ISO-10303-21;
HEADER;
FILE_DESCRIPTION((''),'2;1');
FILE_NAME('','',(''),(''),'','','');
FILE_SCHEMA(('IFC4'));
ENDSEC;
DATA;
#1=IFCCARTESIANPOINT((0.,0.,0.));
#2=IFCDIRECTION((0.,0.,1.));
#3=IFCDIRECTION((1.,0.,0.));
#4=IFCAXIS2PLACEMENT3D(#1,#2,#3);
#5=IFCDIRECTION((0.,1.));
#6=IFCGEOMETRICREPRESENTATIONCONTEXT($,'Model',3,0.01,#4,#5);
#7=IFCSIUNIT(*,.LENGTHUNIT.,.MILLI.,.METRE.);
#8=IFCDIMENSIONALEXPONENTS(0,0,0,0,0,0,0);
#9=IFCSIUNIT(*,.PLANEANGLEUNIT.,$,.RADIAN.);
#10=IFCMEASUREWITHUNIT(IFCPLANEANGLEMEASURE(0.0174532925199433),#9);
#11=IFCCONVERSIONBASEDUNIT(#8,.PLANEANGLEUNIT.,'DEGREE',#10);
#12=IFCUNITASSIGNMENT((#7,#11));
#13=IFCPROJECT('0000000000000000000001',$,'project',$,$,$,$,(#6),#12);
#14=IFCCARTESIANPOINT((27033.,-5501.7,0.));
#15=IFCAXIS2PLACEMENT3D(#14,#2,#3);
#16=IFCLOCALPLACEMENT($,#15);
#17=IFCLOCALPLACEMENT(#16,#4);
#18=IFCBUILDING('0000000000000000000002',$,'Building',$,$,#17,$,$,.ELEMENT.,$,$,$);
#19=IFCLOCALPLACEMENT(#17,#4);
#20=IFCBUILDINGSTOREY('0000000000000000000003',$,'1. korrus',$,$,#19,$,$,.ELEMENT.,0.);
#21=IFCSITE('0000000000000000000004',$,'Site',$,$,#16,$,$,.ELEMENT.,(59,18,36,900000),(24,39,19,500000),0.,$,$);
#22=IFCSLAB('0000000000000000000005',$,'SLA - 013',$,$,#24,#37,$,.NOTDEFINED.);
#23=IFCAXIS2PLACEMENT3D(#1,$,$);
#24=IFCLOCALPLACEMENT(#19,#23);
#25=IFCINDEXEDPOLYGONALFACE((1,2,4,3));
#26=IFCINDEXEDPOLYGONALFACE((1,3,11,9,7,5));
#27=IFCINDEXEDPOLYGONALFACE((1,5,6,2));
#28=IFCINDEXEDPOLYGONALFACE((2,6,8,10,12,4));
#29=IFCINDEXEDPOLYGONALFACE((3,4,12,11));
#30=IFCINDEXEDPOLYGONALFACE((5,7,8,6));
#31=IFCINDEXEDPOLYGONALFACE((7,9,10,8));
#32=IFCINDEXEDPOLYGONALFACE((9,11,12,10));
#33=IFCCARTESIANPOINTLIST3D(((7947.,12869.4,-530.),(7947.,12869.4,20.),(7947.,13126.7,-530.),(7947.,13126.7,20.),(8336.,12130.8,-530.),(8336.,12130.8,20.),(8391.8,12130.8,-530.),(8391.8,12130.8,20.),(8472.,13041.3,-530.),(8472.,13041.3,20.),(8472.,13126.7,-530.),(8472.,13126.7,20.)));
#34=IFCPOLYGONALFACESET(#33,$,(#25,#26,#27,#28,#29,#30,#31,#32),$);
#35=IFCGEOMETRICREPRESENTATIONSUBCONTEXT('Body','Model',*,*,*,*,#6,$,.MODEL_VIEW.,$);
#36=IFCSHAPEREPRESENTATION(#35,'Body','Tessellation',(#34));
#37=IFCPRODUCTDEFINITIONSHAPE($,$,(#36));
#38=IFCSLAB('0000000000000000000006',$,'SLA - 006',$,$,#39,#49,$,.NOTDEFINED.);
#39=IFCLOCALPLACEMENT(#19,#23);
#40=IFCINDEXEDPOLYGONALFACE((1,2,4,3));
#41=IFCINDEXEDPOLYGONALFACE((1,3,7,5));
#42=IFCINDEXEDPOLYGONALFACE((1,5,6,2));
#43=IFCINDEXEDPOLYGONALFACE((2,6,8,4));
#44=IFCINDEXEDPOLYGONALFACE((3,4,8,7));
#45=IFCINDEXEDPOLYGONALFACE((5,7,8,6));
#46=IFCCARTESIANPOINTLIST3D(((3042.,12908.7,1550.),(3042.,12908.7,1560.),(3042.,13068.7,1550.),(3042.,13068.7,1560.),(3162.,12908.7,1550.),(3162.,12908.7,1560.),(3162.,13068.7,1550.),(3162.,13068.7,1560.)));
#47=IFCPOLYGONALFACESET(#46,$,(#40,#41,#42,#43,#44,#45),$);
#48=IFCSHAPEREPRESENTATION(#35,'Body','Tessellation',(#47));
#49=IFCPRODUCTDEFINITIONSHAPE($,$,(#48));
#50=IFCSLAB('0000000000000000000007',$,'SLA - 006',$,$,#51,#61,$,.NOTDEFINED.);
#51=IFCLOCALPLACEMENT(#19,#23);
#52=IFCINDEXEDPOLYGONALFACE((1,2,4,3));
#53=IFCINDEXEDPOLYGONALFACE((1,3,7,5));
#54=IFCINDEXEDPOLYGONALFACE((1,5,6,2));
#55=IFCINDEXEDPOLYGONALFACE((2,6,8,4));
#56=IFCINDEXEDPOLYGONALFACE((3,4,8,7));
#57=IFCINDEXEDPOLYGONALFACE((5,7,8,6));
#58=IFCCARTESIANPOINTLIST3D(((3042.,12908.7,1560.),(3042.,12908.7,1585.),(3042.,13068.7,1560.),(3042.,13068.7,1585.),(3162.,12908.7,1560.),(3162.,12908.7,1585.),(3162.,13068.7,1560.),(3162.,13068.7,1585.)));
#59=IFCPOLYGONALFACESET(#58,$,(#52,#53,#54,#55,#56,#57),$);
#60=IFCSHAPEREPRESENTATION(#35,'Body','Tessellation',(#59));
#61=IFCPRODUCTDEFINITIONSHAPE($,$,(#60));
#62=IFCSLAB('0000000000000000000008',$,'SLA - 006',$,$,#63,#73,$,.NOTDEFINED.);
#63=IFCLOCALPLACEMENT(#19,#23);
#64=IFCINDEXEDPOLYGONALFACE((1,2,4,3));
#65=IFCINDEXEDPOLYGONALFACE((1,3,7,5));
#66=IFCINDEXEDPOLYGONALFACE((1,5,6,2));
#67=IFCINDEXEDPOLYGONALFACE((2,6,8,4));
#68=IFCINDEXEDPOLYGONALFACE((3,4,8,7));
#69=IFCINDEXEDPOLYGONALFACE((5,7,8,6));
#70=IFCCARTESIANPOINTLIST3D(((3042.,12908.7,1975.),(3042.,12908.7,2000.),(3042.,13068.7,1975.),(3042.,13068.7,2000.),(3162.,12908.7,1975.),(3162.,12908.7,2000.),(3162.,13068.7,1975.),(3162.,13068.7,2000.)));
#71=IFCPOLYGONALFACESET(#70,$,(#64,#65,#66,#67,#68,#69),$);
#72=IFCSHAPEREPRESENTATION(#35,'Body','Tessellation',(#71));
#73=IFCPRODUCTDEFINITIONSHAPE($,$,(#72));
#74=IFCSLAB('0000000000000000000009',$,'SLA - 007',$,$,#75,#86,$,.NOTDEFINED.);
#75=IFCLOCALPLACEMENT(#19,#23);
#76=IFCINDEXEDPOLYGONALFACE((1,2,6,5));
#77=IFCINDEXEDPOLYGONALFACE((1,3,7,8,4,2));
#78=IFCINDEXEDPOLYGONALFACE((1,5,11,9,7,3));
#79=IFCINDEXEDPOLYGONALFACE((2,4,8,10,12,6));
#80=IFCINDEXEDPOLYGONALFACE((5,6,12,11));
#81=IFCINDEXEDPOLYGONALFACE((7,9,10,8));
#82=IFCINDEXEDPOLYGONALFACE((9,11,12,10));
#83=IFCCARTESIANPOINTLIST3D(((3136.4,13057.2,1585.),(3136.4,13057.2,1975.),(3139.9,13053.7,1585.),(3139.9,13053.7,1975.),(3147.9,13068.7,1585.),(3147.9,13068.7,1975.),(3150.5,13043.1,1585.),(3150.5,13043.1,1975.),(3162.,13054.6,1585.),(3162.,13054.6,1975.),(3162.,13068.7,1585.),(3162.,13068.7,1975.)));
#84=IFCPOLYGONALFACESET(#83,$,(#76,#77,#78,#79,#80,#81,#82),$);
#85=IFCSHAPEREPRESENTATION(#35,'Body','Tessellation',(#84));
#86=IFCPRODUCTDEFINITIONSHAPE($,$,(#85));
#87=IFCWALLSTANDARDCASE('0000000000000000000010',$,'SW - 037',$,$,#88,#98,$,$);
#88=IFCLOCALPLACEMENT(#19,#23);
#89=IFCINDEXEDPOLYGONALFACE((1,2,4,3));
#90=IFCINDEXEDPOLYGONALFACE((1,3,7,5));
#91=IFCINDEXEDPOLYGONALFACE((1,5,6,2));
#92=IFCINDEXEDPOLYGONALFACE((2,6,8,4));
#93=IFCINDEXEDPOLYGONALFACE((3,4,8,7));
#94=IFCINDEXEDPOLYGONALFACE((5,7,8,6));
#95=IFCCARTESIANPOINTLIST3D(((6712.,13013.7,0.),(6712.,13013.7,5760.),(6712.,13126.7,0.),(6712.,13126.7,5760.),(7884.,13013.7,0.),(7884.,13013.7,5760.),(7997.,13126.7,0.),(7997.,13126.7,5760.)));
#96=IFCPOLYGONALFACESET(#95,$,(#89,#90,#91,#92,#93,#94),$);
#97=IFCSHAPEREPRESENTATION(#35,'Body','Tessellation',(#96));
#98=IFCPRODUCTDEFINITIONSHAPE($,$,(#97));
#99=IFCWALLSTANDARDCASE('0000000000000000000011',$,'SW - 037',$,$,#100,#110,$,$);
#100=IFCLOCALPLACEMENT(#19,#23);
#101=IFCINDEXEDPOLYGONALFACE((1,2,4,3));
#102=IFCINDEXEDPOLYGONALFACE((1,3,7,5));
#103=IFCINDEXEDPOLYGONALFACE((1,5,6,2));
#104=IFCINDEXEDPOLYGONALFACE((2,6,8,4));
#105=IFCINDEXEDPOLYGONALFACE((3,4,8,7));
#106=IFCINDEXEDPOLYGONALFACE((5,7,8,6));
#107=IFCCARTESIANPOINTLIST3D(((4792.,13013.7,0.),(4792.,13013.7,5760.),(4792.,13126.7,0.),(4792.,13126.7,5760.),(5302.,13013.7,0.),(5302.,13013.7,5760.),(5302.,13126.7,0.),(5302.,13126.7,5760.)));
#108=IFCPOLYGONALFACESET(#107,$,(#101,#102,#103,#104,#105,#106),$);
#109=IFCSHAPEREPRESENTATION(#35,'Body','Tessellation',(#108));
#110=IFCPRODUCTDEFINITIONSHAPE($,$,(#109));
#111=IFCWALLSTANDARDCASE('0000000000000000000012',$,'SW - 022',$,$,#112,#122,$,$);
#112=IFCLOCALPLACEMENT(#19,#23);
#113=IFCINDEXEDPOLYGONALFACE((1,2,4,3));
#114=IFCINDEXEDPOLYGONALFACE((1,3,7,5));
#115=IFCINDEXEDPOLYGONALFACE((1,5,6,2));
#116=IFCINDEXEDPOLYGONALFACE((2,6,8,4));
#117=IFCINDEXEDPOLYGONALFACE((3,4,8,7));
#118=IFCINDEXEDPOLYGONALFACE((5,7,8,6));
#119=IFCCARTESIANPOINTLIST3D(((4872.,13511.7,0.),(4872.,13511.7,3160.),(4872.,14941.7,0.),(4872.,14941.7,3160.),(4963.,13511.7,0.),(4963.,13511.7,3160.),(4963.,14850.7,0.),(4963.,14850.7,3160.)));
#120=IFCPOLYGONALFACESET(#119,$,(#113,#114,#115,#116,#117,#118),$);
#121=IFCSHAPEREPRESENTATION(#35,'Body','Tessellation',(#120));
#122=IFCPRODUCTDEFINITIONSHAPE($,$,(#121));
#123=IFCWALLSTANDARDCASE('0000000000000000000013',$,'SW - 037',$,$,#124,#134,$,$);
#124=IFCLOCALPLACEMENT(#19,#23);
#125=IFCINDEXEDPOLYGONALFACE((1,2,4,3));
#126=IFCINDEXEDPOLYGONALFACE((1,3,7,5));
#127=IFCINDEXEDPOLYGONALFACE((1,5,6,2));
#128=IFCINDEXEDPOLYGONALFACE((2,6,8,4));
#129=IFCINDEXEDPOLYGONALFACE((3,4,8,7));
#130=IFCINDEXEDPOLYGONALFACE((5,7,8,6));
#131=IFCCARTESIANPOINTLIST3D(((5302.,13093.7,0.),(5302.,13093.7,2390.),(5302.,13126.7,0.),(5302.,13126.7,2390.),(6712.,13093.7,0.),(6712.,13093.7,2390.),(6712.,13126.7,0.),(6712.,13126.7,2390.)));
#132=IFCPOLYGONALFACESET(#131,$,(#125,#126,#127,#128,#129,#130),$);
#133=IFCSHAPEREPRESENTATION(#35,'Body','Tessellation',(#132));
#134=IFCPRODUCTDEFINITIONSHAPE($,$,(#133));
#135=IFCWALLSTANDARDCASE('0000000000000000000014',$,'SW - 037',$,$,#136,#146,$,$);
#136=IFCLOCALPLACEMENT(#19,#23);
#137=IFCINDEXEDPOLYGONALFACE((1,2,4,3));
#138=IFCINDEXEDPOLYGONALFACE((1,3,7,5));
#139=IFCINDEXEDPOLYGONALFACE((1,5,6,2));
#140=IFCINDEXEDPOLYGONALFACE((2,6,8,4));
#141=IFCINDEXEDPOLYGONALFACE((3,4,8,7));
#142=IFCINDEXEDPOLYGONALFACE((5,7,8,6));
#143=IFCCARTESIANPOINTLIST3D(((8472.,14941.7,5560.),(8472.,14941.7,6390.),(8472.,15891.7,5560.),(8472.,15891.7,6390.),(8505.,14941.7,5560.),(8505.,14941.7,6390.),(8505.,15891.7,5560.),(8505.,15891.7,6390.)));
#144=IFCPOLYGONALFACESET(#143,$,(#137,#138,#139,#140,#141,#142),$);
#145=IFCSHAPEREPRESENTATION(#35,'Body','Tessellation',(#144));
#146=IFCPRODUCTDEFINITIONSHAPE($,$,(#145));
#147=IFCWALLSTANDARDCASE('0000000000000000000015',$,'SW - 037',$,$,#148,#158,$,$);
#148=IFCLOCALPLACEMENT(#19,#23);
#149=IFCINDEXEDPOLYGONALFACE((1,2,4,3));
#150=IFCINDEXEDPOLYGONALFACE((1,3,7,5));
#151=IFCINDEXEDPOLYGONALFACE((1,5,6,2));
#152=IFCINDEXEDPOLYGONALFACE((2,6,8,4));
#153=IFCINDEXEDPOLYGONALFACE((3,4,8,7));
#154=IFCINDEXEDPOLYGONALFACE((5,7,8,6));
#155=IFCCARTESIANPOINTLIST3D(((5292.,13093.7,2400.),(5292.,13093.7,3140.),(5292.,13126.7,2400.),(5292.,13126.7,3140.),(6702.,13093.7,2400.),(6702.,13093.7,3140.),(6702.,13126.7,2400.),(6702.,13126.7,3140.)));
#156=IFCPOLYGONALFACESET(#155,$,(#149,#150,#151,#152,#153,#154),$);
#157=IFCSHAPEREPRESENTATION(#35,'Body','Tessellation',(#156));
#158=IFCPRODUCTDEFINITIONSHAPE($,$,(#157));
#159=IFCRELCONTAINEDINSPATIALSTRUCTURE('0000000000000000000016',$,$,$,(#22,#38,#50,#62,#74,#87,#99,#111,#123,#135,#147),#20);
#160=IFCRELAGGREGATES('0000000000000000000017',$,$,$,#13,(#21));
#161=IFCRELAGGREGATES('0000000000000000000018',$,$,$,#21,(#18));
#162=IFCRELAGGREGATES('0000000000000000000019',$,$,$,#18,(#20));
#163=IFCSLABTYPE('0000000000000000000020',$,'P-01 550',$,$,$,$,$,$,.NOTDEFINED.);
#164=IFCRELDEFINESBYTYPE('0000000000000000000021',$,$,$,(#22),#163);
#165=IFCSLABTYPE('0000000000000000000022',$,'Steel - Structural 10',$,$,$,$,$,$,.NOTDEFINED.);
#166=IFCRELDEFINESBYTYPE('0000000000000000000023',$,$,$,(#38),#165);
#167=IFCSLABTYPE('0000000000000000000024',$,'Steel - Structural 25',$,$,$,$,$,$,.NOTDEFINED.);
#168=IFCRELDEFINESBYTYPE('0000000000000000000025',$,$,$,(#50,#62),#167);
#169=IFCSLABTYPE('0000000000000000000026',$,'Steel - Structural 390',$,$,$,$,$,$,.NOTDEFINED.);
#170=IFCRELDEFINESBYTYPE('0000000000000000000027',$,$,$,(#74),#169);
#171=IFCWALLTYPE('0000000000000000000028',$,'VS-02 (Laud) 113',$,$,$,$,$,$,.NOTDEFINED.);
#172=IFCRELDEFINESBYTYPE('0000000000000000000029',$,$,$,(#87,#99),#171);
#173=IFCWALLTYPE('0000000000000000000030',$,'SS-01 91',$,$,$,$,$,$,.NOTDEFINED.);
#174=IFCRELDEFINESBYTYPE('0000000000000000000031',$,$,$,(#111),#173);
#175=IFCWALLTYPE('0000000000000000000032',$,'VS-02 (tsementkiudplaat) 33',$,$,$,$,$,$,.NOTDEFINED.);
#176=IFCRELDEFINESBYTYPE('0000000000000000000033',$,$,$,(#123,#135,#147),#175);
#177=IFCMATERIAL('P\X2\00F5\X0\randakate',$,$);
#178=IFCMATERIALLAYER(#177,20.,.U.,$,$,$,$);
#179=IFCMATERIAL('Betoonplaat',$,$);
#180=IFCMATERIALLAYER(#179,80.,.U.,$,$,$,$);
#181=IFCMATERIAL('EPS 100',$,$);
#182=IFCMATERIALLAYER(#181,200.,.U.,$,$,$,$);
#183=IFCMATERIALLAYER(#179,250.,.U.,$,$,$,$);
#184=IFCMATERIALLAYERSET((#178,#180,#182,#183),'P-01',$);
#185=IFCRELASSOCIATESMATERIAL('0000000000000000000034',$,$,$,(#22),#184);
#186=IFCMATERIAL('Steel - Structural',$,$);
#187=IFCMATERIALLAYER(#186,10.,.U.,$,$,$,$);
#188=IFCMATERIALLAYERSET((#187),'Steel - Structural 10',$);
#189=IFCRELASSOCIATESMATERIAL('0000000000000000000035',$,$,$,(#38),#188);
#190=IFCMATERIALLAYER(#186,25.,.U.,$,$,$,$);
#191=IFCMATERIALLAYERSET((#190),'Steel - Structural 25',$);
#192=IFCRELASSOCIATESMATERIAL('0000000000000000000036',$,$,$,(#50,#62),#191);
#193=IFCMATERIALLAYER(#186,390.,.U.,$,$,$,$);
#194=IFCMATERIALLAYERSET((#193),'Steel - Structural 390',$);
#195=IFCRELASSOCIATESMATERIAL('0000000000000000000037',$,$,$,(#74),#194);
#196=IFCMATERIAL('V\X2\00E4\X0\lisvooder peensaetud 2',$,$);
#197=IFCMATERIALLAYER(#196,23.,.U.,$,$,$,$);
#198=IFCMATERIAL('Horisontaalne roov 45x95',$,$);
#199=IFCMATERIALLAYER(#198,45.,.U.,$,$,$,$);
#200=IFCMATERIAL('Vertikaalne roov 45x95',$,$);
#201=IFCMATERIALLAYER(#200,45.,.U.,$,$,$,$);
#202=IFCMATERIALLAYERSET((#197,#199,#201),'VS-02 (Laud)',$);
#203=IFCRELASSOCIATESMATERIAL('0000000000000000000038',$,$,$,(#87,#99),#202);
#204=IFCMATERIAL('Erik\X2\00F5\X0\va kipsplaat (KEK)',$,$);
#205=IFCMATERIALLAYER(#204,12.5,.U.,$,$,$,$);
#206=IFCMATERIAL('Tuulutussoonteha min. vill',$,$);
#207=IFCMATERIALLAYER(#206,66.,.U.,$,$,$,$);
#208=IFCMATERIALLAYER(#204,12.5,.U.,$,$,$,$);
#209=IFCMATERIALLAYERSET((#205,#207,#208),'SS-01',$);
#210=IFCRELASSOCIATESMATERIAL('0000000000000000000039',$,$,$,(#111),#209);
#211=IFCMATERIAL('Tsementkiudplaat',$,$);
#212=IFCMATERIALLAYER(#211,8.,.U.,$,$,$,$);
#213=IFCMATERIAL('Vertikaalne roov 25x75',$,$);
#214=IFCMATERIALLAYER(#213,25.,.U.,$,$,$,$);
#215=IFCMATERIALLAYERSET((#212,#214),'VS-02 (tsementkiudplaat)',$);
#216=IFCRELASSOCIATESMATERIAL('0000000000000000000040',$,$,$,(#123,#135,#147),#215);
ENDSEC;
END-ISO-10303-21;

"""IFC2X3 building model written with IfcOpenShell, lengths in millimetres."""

from ifc_helpers import new_model, entity, si_unit, converted_unit, direction, frame, origin_with_axes, place, context, subcontext, project, spatial, polyline, outline, extrude, material, layer, layer_set, layer_usage, type_object, element, save


model = new_model("IFC2X3")

# Units and contexts
model_context = context("Model", 3, precision=0.01, world=origin_with_axes(), true_north=direction((0.0, 1.0)))
body_context = subcontext(model_context, "Body", "Model", "MODEL_VIEW")
ifc_project = project(units=[si_unit("LENGTHUNIT", "METRE", prefix="MILLI"), converted_unit("PLANEANGLEUNIT", "DEGREE", entity("IfcPlaneAngleMeasure", 0.0174532925199433), si_unit("PLANEANGLEUNIT", "RADIAN"), dimensions=[0, 0, 0, 0, 0, 0, 0])], contexts=[model_context])

# Site, building, storey
site_placement = place(None, frame((27033.0, -5501.7, 0.0), z_axis=(0.0, 0.0, 1.0), x_axis=(1.0, 0.0, 0.0)))
site = spatial("IfcSite", under=ifc_project, at=site_placement, Name="Site", CompositionType="ELEMENT", RefLatitude=(59, 18, 36, 900000), RefLongitude=(24, 39, 19, 500000), RefElevation=0.0)
building_placement = place(site_placement, origin_with_axes())
building = spatial("IfcBuilding", under=site, at=building_placement, Name="Building", CompositionType="ELEMENT")
storey_placement = place(building_placement, origin_with_axes())
storey = spatial("IfcBuildingStorey", under=building, at=storey_placement, Name="1. korrus", CompositionType="ELEMENT", Elevation=0.0)

# Slabs
ifc_material_1 = material(Name="Põrandakate")
ifc_layer_1 = layer(ifc_material_1, 20.0, ventilated="UNKNOWN")
ifc_material_2 = material(Name="Betoonplaat")
ifc_layer_2 = layer(ifc_material_2, 80.0, ventilated="UNKNOWN")
ifc_material_3 = material(Name="EPS 100")
ifc_layer_3 = layer(ifc_material_3, 200.0, ventilated="UNKNOWN")
ifc_layer_4 = layer(ifc_material_2, 250.0, ventilated="UNKNOWN")
ifc_layer_set_1 = layer_set([ifc_layer_1, ifc_layer_2, ifc_layer_3, ifc_layer_4], Name="P-01")
ifc_layer_usage_1 = layer_usage(ifc_layer_set_1, "AXIS3", "NEGATIVE", 550.0)
slab_type_1 = type_object("IfcSlabType", Name="P-01 550", PredefinedType="NOTDEFINED")
slab_1_placement = place(storey_placement, frame((7947.0, 13126.7, 0.0), z_axis=(0.0, 0.0, 1.0), x_axis=(1.0, 0.0, 0.0)))
element("IfcSlab", 1, at=slab_1_placement, inside=storey, type_object=slab_type_1, material=ifc_layer_usage_1, Name="SLA - 013", PredefinedType="NOTDEFINED", context=body_context, shape_type="SweptSolid", body=[
    extrude(outline(polyline([(0.0, 0.0), (0.0, -257.3), (389.0, -995.9), (444.8, -995.9), (525.0, -85.4), (525.0, 0.0), (0.0, 0.0)])), frame((0.0, 0.0, -530.0), z_axis=(0.0, 0.0, 1.0), x_axis=(1.0, 0.0, 0.0)), (0.0, 0.0, 1.0), 550.0),
])
ifc_material_4 = material(Name="Steel - Structural")
ifc_layer_5 = layer(ifc_material_4, 10.0, ventilated="UNKNOWN")
ifc_layer_set_2 = layer_set([ifc_layer_5], Name="Steel - Structural 10")
ifc_layer_usage_2 = layer_usage(ifc_layer_set_2, "AXIS3", "NEGATIVE", 10.0)
slab_type_2 = type_object("IfcSlabType", Name="Steel - Structural 10", PredefinedType="NOTDEFINED")
slab_2_placement = place(storey_placement, frame((3162.0, 13068.7, 1550.0), z_axis=(0.0, 0.0, 1.0), x_axis=(1.0, 0.0, 0.0)))
element("IfcSlab", 2, at=slab_2_placement, inside=storey, type_object=slab_type_2, material=ifc_layer_usage_2, Name="SLA - 006", PredefinedType="NOTDEFINED", context=body_context, shape_type="SweptSolid", body=[
    extrude(outline(polyline([(0.0, 0.0), (-120.0, 0.0), (-120.0, -160.0), (0.0, -160.0), (0.0, 0.0)])), origin_with_axes(), (0.0, 0.0, 1.0), 10.0),
])
ifc_layer_6 = layer(ifc_material_4, 25.0, ventilated="UNKNOWN")
ifc_layer_set_3 = layer_set([ifc_layer_6], Name="Steel - Structural 25")
ifc_layer_usage_3 = layer_usage(ifc_layer_set_3, "AXIS3", "NEGATIVE", 25.0)
slab_type_3 = type_object("IfcSlabType", Name="Steel - Structural 25", PredefinedType="NOTDEFINED")
slab_3_placement = place(storey_placement, frame((3162.0, 13068.7, 1560.0), z_axis=(0.0, 0.0, 1.0), x_axis=(1.0, 0.0, 0.0)))
element("IfcSlab", 3, at=slab_3_placement, inside=storey, type_object=slab_type_3, material=ifc_layer_usage_3, Name="SLA - 006", PredefinedType="NOTDEFINED", context=body_context, shape_type="SweptSolid", body=[
    extrude(outline(polyline([(0.0, 0.0), (-120.0, 0.0), (-120.0, -160.0), (0.0, -160.0), (0.0, 0.0)])), origin_with_axes(), (0.0, 0.0, 1.0), 25.0),
])
ifc_layer_usage_4 = layer_usage(ifc_layer_set_3, "AXIS3", "NEGATIVE", 25.0)
slab_4_placement = place(storey_placement, frame((3162.0, 13068.7, 2000.0), z_axis=(0.0, 0.0, 1.0), x_axis=(1.0, 0.0, 0.0)))
element("IfcSlab", 4, at=slab_4_placement, inside=storey, type_object=slab_type_3, material=ifc_layer_usage_4, Name="SLA - 006", PredefinedType="NOTDEFINED", context=body_context, shape_type="SweptSolid", body=[
    extrude(outline(polyline([(0.0, 0.0), (-120.0, 0.0), (-120.0, -160.0), (0.0, -160.0), (0.0, 0.0)])), frame((0.0, 0.0, -25.0), z_axis=(0.0, 0.0, 1.0), x_axis=(1.0, 0.0, 0.0)), (0.0, 0.0, 1.0), 25.0),
])
ifc_layer_7 = layer(ifc_material_4, 390.0, ventilated="UNKNOWN")
ifc_layer_set_4 = layer_set([ifc_layer_7], Name="Steel - Structural 390")
ifc_layer_usage_5 = layer_usage(ifc_layer_set_4, "AXIS3", "NEGATIVE", 390.0)
slab_type_4 = type_object("IfcSlabType", Name="Steel - Structural 390", PredefinedType="NOTDEFINED")
slab_5_placement = place(storey_placement, frame((3147.9, 13068.7, 1585.0), z_axis=(0.0, 0.0, 1.0), x_axis=(1.0, 0.0, 0.0)))
element("IfcSlab", 5, at=slab_5_placement, inside=storey, type_object=slab_type_4, material=ifc_layer_usage_5, Name="SLA - 007", PredefinedType="NOTDEFINED", context=body_context, shape_type="SweptSolid", body=[
    extrude(outline(polyline([(0.0, 0.0), (-11.5, -11.5), (-7.9, -15.0), (2.7, -25.6), (14.1, -14.1), (14.1, 0.0), (0.0, 0.0)])), origin_with_axes(), (0.0, 0.0, 1.0), 390.0),
])

# Walls
ifc_material_5 = material(Name="Välisvooder peensaetud 2")
ifc_layer_8 = layer(ifc_material_5, 23.0, ventilated="UNKNOWN")
ifc_material_6 = material(Name="Horisontaalne roov 45x95")
ifc_layer_9 = layer(ifc_material_6, 45.0, ventilated="UNKNOWN")
ifc_material_7 = material(Name="Vertikaalne roov 45x95")
ifc_layer_10 = layer(ifc_material_7, 45.0, ventilated="UNKNOWN")
ifc_layer_set_5 = layer_set([ifc_layer_8, ifc_layer_9, ifc_layer_10], Name="VS-02 (Laud)")
ifc_layer_usage_6 = layer_usage(ifc_layer_set_5, "AXIS2", "POSITIVE", -113.0)
wall_type_1 = type_object("IfcWallType", Name="VS-02 (Laud) 113", PredefinedType="NOTDEFINED")
wall_1_placement = place(storey_placement, frame((6712.0, 13126.7, 0.0), z_axis=(0.0, 0.0, 1.0), x_axis=(1.0, 0.0, 0.0)))
element("IfcWallStandardCase", 6, at=wall_1_placement, inside=storey, type_object=wall_type_1, material=ifc_layer_usage_6, Name="SW - 037", context=body_context, shape_type="SweptSolid", body=[
    extrude(outline(polyline([(0.0, -113.0), (1172.0, -113.0), (1285.0, 0.0), (0.0, 0.0), (0.0, -113.0)])), origin_with_axes(), (0.0, 0.0, 1.0), 5760.0),
])
ifc_layer_usage_7 = layer_usage(ifc_layer_set_5, "AXIS2", "POSITIVE", -113.0)
wall_2_placement = place(storey_placement, frame((4792.0, 13126.7, 0.0), z_axis=(0.0, 0.0, 1.0), x_axis=(1.0, -0.000001, 0.0)))
element("IfcWallStandardCase", 7, at=wall_2_placement, inside=storey, type_object=wall_type_1, material=ifc_layer_usage_7, Name="SW - 037", context=body_context, shape_type="SweptSolid", body=[
    extrude(outline(polyline([(0.0, -113.0), (510.0, -113.0), (510.0, 0.0), (0.0, 0.0), (0.0, -113.0)])), origin_with_axes(), (0.0, 0.0, 1.0), 5760.0),
])
ifc_material_8 = material(Name="Erikõva kipsplaat (KEK)")
ifc_layer_11 = layer(ifc_material_8, 12.5, ventilated="UNKNOWN")
ifc_material_9 = material(Name="Tuulutussoonteha min. vill")
ifc_layer_12 = layer(ifc_material_9, 66.0, ventilated="UNKNOWN")
ifc_layer_13 = layer(ifc_material_8, 12.5, ventilated="UNKNOWN")
ifc_layer_set_6 = layer_set([ifc_layer_11, ifc_layer_12, ifc_layer_13], Name="SS-01")
ifc_layer_usage_8 = layer_usage(ifc_layer_set_6, "AXIS2", "POSITIVE", -91.0)
wall_type_2 = type_object("IfcWallType", Name="SS-01 91", PredefinedType="NOTDEFINED")
wall_3_placement = place(storey_placement, frame((4872.0, 13511.7, 0.0), z_axis=(0.0, 0.0, 1.0), x_axis=(0.0, 1.0, 0.0)))
element("IfcWallStandardCase", 8, at=wall_3_placement, inside=storey, type_object=wall_type_2, material=ifc_layer_usage_8, Name="SW - 022", context=body_context, shape_type="SweptSolid", body=[
    extrude(outline(polyline([(0.0, -91.0), (1339.0, -91.0), (1430.0, 0.0), (0.0, 0.0), (0.0, -91.0)])), origin_with_axes(), (0.0, 0.0, 1.0), 3160.0),
])
ifc_material_10 = material(Name="Tsementkiudplaat")
ifc_layer_14 = layer(ifc_material_10, 8.0, ventilated="UNKNOWN")
ifc_material_11 = material(Name="Vertikaalne roov 25x75")
ifc_layer_15 = layer(ifc_material_11, 25.0, ventilated="UNKNOWN")
ifc_layer_set_7 = layer_set([ifc_layer_14, ifc_layer_15], Name="VS-02 (tsementkiudplaat)")
ifc_layer_usage_9 = layer_usage(ifc_layer_set_7, "AXIS2", "POSITIVE", -33.0)
wall_type_3 = type_object("IfcWallType", Name="VS-02 (tsementkiudplaat) 33", PredefinedType="NOTDEFINED")
wall_4_placement = place(storey_placement, frame((5302.0, 13126.7, 0.0), z_axis=(0.0, 0.0, 1.0), x_axis=(1.0, -0.000001, 0.0)))
element("IfcWallStandardCase", 9, at=wall_4_placement, inside=storey, type_object=wall_type_3, material=ifc_layer_usage_9, Name="SW - 037", context=body_context, shape_type="SweptSolid", body=[
    extrude(outline(polyline([(0.0, -33.0), (1410.0, -33.0), (1410.0, 0.0), (0.0, 0.0), (0.0, -33.0)])), origin_with_axes(), (0.0, 0.0, 1.0), 2390.0),
])
ifc_layer_usage_10 = layer_usage(ifc_layer_set_7, "AXIS2", "POSITIVE", -33.0)
wall_5_placement = place(storey_placement, frame((8472.0, 14941.7, 5560.0), z_axis=(0.0, 0.0, 1.0), x_axis=(0.0, 1.0, 0.0)))
element("IfcWallStandardCase", 10, at=wall_5_placement, inside=storey, type_object=wall_type_3, material=ifc_layer_usage_10, Name="SW - 037", context=body_context, shape_type="SweptSolid", body=[
    extrude(outline(polyline([(0.0, -33.0), (950.0, -33.0), (950.0, 0.0), (0.0, 0.0), (0.0, -33.0)])), origin_with_axes(), (0.0, 0.0, 1.0), 830.0),
])
ifc_layer_usage_11 = layer_usage(ifc_layer_set_7, "AXIS2", "POSITIVE", -33.0)
wall_6_placement = place(storey_placement, frame((5292.0, 13126.7, 2400.0), z_axis=(0.0, 0.0, 1.0), x_axis=(1.0, -0.000001, 0.0)))
element("IfcWallStandardCase", 11, at=wall_6_placement, inside=storey, type_object=wall_type_3, material=ifc_layer_usage_11, Name="SW - 037", context=body_context, shape_type="SweptSolid", body=[
    extrude(outline(polyline([(0.0, -33.0), (1410.0, -33.0), (1410.0, 0.0), (0.0, 0.0), (0.0, -33.0)])), origin_with_axes(), (0.0, 0.0, 1.0), 740.0),
])

save(model, "model.ifc")
